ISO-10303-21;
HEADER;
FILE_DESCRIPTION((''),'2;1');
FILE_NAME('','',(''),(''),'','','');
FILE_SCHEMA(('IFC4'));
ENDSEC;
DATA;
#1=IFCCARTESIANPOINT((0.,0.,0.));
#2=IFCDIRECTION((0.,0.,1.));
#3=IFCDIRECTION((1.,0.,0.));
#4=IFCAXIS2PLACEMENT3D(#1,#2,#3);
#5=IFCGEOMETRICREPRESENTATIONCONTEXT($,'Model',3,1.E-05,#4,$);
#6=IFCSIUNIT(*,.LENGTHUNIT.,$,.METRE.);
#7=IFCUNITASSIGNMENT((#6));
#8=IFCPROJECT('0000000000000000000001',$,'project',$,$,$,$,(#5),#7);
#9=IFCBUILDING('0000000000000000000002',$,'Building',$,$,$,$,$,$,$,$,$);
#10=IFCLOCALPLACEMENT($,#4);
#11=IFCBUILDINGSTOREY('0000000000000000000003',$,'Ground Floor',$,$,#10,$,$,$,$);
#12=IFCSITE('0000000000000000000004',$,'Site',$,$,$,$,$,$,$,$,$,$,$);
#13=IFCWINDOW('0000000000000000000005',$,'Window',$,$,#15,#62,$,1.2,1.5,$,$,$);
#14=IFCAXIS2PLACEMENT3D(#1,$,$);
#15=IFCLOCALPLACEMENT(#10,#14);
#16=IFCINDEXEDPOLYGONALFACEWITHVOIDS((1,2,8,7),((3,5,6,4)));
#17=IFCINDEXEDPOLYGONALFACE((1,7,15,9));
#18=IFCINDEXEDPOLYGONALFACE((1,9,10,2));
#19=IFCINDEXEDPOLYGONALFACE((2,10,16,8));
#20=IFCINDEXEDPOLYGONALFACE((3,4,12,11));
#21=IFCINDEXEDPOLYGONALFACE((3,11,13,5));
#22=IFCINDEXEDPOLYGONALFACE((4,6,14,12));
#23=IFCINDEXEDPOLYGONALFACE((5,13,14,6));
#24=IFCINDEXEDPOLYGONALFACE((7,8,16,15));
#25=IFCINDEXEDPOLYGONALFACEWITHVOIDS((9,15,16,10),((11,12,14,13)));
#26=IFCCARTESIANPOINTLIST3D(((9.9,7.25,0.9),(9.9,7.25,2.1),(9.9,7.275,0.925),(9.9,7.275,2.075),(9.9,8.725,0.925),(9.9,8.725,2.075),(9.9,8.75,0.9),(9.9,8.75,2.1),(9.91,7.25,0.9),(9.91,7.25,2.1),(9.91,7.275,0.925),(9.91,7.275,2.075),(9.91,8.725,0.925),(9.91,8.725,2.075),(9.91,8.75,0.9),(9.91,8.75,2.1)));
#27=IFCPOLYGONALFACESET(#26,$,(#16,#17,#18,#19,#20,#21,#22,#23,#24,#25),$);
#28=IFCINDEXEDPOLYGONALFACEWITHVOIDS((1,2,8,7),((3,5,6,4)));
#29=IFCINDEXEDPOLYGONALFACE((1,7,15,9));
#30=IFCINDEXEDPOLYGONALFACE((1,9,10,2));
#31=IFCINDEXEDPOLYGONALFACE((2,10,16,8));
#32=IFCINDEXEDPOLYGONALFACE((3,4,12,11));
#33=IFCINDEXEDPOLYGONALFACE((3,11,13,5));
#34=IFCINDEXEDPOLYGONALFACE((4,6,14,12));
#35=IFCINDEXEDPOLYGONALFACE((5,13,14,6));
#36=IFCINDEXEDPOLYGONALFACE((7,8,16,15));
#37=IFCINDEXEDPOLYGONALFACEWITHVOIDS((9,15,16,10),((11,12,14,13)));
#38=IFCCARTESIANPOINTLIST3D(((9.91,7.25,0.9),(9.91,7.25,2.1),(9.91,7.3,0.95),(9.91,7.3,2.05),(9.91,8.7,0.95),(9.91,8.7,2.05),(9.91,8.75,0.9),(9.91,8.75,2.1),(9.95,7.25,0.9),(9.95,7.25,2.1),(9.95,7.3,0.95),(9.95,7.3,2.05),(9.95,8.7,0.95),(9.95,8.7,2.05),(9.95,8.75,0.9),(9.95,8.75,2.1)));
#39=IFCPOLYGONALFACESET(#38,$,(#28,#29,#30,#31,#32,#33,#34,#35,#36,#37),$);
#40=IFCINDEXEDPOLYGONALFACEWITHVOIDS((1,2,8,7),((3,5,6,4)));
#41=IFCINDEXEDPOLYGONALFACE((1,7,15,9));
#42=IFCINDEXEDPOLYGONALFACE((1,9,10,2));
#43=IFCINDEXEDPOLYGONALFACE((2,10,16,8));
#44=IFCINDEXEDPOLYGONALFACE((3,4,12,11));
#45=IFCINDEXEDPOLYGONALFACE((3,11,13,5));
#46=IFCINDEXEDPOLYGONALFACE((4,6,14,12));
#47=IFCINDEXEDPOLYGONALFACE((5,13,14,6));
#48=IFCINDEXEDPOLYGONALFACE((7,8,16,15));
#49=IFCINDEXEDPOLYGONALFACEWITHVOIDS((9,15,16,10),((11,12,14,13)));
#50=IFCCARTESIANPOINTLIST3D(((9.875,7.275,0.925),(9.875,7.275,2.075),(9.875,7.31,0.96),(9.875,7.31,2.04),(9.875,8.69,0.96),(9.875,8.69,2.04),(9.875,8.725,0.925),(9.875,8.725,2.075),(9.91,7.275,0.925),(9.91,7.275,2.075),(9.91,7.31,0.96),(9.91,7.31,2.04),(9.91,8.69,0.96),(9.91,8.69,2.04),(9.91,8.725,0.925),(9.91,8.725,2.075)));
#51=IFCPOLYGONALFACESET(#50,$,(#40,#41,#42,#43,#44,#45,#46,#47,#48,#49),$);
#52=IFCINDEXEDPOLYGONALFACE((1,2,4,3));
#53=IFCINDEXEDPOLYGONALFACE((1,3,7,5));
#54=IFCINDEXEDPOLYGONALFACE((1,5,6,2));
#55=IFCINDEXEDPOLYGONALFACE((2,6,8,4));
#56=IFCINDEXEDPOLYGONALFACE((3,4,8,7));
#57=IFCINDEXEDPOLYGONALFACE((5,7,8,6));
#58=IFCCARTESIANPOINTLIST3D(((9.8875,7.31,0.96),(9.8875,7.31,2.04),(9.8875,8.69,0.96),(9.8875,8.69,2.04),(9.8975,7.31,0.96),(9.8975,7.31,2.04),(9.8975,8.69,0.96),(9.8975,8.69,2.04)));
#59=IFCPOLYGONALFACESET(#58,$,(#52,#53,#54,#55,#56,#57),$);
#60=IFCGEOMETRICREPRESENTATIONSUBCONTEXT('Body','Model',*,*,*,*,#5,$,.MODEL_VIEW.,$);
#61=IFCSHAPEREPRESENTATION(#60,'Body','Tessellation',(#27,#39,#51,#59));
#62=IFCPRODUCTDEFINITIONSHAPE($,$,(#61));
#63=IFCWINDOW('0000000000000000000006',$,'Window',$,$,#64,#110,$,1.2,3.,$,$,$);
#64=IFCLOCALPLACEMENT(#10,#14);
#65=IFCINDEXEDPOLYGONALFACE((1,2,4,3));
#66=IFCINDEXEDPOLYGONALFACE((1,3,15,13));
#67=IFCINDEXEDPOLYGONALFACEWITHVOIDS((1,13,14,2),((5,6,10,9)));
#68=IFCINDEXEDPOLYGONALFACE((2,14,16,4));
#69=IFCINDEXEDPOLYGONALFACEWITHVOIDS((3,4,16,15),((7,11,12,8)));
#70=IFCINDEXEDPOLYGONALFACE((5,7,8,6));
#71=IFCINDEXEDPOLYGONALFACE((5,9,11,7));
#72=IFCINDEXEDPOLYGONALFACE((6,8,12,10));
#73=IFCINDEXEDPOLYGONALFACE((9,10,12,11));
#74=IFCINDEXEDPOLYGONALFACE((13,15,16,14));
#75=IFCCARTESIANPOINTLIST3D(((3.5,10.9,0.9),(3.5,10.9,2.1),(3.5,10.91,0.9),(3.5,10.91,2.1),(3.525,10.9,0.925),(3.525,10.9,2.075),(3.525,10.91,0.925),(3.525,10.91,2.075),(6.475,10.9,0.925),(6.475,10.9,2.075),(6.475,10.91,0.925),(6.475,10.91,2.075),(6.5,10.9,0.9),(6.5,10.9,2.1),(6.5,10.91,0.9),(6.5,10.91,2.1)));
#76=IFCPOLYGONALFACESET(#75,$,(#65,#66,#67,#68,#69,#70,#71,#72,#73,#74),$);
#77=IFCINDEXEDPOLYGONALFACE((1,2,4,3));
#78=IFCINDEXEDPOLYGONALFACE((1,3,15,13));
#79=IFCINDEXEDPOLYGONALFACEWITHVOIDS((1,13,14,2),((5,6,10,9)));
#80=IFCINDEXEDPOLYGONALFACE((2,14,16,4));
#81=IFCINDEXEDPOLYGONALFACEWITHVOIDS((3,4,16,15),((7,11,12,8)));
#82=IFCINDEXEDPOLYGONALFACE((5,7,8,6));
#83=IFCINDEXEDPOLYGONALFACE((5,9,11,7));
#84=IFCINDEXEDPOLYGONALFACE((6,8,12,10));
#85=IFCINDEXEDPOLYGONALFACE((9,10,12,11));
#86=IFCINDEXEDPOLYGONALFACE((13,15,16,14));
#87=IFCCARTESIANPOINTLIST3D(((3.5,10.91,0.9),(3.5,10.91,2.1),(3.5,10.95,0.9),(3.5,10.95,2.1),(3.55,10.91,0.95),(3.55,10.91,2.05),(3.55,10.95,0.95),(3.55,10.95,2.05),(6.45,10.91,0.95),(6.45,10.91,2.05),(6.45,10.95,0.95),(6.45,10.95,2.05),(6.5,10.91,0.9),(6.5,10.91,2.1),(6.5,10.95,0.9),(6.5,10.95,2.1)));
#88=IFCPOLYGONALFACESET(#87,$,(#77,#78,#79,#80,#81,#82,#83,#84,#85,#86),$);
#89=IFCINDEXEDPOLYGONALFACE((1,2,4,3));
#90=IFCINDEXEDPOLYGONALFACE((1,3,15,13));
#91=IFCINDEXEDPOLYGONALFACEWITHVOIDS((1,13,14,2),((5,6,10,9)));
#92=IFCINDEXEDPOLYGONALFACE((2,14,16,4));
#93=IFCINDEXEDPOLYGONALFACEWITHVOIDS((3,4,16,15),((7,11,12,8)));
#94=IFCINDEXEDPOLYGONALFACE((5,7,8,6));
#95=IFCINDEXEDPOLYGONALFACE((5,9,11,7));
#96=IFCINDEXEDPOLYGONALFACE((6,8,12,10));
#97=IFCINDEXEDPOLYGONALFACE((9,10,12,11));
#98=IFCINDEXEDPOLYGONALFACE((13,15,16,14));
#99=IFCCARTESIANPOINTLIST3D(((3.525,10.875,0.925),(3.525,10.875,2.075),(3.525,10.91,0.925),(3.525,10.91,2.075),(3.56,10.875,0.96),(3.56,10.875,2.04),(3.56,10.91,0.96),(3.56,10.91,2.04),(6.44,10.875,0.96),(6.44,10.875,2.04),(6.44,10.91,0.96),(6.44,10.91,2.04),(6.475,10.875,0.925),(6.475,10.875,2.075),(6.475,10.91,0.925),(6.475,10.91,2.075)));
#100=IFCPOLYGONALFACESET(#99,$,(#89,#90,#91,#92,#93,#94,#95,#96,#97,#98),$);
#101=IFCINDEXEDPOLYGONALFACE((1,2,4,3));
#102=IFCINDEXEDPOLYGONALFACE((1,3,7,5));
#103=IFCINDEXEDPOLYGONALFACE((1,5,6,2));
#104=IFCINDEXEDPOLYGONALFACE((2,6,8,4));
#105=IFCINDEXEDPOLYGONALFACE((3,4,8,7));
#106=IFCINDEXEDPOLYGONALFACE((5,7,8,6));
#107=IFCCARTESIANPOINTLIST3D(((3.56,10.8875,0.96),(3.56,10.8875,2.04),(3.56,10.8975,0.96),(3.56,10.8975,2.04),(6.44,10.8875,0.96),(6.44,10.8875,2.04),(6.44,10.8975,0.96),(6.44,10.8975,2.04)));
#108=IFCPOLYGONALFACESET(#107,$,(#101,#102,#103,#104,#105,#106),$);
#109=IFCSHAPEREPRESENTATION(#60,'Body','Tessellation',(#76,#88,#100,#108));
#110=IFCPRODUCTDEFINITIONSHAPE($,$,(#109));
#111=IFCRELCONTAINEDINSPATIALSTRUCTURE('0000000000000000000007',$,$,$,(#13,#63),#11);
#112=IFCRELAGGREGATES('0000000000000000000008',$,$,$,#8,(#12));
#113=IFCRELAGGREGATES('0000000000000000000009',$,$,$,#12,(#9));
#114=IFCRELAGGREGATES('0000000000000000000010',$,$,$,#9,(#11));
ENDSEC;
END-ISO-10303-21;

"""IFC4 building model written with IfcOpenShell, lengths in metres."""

from ifc_helpers import new_model, si_unit, frame, origin_with_axes, place, context, subcontext, project, spatial, line, indexed_curve, outline, extrude, element, save


model = new_model("IFC4")

# Units and contexts
model_context = context("Model", 3, precision=1e-05, world=origin_with_axes())
body_context = subcontext(model_context, "Body", "Model", "MODEL_VIEW")
ifc_project = project(units=[si_unit("LENGTHUNIT", "METRE")], contexts=[model_context])

# Site, building, storey
site = spatial("IfcSite", under=ifc_project, Name="Site")
building = spatial("IfcBuilding", under=site, Name="Building")
storey_placement = place(None, origin_with_axes())
storey = spatial("IfcBuildingStorey", under=building, at=storey_placement, Name="Ground Floor")

# Windows
window_1_placement = place(storey_placement, frame((10.0, 7.25, 0.9), z_axis=(0.0, 0.0, 1.0), x_axis=(0.0, 1.0, 0.0)))
element("IfcWindow", 1, at=window_1_placement, inside=storey, Name="Window", OverallHeight=1.2, OverallWidth=1.5, context=body_context, shape_type="SweptSolid", body=[
    extrude(outline(indexed_curve([(0.0, 0.0), (1.5, 0.0), (1.5, 1.2), (0.0, 1.2)], segments=[line(1, 2, 3, 4, 1)]), holes=[indexed_curve([(0.025, 0.025), (1.475, 0.025), (1.475, 1.175), (0.025, 1.175)], segments=[line(1, 2, 3, 4, 1)])]), frame((0.0, 0.09, 0.0), z_axis=(0.0, -1.0, 0.0), x_axis=(1.0, 0.0, 0.0)), (0.0, 0.0, -1.0), 0.01),
    extrude(outline(indexed_curve([(0.0, 0.0), (1.5, 0.0), (1.5, 1.2), (0.0, 1.2)], segments=[line(1, 2, 3, 4, 1)]), holes=[indexed_curve([(0.05, 0.05), (1.45, 0.05), (1.45, 1.15), (0.05, 1.15)], segments=[line(1, 2, 3, 4, 1)])]), frame((0.0, 0.05, 0.0), z_axis=(0.0, -1.0, 0.0), x_axis=(1.0, 0.0, 0.0)), (0.0, 0.0, -1.0), 0.04),
    extrude(outline(indexed_curve([(0.0, 0.0), (1.45, 0.0), (1.45, 1.15), (0.0, 1.15)], segments=[line(1, 2, 3, 4, 1)]), holes=[indexed_curve([(0.035, 0.035), (1.415, 0.035), (1.415, 1.115), (0.035, 1.115)], segments=[line(1, 2, 3, 4, 1)])]), frame((0.025, 0.09, 0.025), z_axis=(0.0, -1.0, 0.0), x_axis=(1.0, 0.0, 0.0)), (0.0, 0.0, -1.0), 0.035),
    extrude(outline(indexed_curve([(0.035, 0.035), (1.415, 0.035), (1.415, 1.115), (0.035, 1.115)], segments=[line(1, 2, 3, 4, 1)])), frame((0.025, 0.1025, 0.025), z_axis=(0.0, -1.0, 0.0), x_axis=(1.0, 0.0, 0.0)), (0.0, 0.0, -1.0), 0.01),
])
window_2_placement = place(storey_placement, frame((6.5, 11.0, 0.9), z_axis=(0.0, 0.0, 1.0), x_axis=(-1.0, 0.0, 0.0)))
element("IfcWindow", 2, at=window_2_placement, inside=storey, Name="Window", OverallHeight=1.2, OverallWidth=3.0, context=body_context, shape_type="SweptSolid", body=[
    extrude(outline(indexed_curve([(0.0, 0.0), (3.0, 0.0), (3.0, 1.2), (0.0, 1.2)], segments=[line(1, 2, 3, 4, 1)]), holes=[indexed_curve([(0.025, 0.025), (2.975, 0.025), (2.975, 1.175), (0.025, 1.175)], segments=[line(1, 2, 3, 4, 1)])]), frame((0.0, 0.09, 0.0), z_axis=(0.0, -1.0, 0.0), x_axis=(1.0, 0.0, 0.0)), (0.0, 0.0, -1.0), 0.01),
    extrude(outline(indexed_curve([(0.0, 0.0), (3.0, 0.0), (3.0, 1.2), (0.0, 1.2)], segments=[line(1, 2, 3, 4, 1)]), holes=[indexed_curve([(0.05, 0.05), (2.95, 0.05), (2.95, 1.15), (0.05, 1.15)], segments=[line(1, 2, 3, 4, 1)])]), frame((0.0, 0.05, 0.0), z_axis=(0.0, -1.0, 0.0), x_axis=(1.0, 0.0, 0.0)), (0.0, 0.0, -1.0), 0.04),
    extrude(outline(indexed_curve([(0.0, 0.0), (2.95, 0.0), (2.95, 1.15), (0.0, 1.15)], segments=[line(1, 2, 3, 4, 1)]), holes=[indexed_curve([(0.035, 0.035), (2.915, 0.035), (2.915, 1.115), (0.035, 1.115)], segments=[line(1, 2, 3, 4, 1)])]), frame((0.025, 0.09, 0.025), z_axis=(0.0, -1.0, 0.0), x_axis=(1.0, 0.0, 0.0)), (0.0, 0.0, -1.0), 0.035),
    extrude(outline(indexed_curve([(0.035, 0.035), (2.915, 0.035), (2.915, 1.115), (0.035, 1.115)], segments=[line(1, 2, 3, 4, 1)])), frame((0.025, 0.1025, 0.025), z_axis=(0.0, -1.0, 0.0), x_axis=(1.0, 0.0, 0.0)), (0.0, 0.0, -1.0), 0.01),
])

save(model, "model.ifc")
